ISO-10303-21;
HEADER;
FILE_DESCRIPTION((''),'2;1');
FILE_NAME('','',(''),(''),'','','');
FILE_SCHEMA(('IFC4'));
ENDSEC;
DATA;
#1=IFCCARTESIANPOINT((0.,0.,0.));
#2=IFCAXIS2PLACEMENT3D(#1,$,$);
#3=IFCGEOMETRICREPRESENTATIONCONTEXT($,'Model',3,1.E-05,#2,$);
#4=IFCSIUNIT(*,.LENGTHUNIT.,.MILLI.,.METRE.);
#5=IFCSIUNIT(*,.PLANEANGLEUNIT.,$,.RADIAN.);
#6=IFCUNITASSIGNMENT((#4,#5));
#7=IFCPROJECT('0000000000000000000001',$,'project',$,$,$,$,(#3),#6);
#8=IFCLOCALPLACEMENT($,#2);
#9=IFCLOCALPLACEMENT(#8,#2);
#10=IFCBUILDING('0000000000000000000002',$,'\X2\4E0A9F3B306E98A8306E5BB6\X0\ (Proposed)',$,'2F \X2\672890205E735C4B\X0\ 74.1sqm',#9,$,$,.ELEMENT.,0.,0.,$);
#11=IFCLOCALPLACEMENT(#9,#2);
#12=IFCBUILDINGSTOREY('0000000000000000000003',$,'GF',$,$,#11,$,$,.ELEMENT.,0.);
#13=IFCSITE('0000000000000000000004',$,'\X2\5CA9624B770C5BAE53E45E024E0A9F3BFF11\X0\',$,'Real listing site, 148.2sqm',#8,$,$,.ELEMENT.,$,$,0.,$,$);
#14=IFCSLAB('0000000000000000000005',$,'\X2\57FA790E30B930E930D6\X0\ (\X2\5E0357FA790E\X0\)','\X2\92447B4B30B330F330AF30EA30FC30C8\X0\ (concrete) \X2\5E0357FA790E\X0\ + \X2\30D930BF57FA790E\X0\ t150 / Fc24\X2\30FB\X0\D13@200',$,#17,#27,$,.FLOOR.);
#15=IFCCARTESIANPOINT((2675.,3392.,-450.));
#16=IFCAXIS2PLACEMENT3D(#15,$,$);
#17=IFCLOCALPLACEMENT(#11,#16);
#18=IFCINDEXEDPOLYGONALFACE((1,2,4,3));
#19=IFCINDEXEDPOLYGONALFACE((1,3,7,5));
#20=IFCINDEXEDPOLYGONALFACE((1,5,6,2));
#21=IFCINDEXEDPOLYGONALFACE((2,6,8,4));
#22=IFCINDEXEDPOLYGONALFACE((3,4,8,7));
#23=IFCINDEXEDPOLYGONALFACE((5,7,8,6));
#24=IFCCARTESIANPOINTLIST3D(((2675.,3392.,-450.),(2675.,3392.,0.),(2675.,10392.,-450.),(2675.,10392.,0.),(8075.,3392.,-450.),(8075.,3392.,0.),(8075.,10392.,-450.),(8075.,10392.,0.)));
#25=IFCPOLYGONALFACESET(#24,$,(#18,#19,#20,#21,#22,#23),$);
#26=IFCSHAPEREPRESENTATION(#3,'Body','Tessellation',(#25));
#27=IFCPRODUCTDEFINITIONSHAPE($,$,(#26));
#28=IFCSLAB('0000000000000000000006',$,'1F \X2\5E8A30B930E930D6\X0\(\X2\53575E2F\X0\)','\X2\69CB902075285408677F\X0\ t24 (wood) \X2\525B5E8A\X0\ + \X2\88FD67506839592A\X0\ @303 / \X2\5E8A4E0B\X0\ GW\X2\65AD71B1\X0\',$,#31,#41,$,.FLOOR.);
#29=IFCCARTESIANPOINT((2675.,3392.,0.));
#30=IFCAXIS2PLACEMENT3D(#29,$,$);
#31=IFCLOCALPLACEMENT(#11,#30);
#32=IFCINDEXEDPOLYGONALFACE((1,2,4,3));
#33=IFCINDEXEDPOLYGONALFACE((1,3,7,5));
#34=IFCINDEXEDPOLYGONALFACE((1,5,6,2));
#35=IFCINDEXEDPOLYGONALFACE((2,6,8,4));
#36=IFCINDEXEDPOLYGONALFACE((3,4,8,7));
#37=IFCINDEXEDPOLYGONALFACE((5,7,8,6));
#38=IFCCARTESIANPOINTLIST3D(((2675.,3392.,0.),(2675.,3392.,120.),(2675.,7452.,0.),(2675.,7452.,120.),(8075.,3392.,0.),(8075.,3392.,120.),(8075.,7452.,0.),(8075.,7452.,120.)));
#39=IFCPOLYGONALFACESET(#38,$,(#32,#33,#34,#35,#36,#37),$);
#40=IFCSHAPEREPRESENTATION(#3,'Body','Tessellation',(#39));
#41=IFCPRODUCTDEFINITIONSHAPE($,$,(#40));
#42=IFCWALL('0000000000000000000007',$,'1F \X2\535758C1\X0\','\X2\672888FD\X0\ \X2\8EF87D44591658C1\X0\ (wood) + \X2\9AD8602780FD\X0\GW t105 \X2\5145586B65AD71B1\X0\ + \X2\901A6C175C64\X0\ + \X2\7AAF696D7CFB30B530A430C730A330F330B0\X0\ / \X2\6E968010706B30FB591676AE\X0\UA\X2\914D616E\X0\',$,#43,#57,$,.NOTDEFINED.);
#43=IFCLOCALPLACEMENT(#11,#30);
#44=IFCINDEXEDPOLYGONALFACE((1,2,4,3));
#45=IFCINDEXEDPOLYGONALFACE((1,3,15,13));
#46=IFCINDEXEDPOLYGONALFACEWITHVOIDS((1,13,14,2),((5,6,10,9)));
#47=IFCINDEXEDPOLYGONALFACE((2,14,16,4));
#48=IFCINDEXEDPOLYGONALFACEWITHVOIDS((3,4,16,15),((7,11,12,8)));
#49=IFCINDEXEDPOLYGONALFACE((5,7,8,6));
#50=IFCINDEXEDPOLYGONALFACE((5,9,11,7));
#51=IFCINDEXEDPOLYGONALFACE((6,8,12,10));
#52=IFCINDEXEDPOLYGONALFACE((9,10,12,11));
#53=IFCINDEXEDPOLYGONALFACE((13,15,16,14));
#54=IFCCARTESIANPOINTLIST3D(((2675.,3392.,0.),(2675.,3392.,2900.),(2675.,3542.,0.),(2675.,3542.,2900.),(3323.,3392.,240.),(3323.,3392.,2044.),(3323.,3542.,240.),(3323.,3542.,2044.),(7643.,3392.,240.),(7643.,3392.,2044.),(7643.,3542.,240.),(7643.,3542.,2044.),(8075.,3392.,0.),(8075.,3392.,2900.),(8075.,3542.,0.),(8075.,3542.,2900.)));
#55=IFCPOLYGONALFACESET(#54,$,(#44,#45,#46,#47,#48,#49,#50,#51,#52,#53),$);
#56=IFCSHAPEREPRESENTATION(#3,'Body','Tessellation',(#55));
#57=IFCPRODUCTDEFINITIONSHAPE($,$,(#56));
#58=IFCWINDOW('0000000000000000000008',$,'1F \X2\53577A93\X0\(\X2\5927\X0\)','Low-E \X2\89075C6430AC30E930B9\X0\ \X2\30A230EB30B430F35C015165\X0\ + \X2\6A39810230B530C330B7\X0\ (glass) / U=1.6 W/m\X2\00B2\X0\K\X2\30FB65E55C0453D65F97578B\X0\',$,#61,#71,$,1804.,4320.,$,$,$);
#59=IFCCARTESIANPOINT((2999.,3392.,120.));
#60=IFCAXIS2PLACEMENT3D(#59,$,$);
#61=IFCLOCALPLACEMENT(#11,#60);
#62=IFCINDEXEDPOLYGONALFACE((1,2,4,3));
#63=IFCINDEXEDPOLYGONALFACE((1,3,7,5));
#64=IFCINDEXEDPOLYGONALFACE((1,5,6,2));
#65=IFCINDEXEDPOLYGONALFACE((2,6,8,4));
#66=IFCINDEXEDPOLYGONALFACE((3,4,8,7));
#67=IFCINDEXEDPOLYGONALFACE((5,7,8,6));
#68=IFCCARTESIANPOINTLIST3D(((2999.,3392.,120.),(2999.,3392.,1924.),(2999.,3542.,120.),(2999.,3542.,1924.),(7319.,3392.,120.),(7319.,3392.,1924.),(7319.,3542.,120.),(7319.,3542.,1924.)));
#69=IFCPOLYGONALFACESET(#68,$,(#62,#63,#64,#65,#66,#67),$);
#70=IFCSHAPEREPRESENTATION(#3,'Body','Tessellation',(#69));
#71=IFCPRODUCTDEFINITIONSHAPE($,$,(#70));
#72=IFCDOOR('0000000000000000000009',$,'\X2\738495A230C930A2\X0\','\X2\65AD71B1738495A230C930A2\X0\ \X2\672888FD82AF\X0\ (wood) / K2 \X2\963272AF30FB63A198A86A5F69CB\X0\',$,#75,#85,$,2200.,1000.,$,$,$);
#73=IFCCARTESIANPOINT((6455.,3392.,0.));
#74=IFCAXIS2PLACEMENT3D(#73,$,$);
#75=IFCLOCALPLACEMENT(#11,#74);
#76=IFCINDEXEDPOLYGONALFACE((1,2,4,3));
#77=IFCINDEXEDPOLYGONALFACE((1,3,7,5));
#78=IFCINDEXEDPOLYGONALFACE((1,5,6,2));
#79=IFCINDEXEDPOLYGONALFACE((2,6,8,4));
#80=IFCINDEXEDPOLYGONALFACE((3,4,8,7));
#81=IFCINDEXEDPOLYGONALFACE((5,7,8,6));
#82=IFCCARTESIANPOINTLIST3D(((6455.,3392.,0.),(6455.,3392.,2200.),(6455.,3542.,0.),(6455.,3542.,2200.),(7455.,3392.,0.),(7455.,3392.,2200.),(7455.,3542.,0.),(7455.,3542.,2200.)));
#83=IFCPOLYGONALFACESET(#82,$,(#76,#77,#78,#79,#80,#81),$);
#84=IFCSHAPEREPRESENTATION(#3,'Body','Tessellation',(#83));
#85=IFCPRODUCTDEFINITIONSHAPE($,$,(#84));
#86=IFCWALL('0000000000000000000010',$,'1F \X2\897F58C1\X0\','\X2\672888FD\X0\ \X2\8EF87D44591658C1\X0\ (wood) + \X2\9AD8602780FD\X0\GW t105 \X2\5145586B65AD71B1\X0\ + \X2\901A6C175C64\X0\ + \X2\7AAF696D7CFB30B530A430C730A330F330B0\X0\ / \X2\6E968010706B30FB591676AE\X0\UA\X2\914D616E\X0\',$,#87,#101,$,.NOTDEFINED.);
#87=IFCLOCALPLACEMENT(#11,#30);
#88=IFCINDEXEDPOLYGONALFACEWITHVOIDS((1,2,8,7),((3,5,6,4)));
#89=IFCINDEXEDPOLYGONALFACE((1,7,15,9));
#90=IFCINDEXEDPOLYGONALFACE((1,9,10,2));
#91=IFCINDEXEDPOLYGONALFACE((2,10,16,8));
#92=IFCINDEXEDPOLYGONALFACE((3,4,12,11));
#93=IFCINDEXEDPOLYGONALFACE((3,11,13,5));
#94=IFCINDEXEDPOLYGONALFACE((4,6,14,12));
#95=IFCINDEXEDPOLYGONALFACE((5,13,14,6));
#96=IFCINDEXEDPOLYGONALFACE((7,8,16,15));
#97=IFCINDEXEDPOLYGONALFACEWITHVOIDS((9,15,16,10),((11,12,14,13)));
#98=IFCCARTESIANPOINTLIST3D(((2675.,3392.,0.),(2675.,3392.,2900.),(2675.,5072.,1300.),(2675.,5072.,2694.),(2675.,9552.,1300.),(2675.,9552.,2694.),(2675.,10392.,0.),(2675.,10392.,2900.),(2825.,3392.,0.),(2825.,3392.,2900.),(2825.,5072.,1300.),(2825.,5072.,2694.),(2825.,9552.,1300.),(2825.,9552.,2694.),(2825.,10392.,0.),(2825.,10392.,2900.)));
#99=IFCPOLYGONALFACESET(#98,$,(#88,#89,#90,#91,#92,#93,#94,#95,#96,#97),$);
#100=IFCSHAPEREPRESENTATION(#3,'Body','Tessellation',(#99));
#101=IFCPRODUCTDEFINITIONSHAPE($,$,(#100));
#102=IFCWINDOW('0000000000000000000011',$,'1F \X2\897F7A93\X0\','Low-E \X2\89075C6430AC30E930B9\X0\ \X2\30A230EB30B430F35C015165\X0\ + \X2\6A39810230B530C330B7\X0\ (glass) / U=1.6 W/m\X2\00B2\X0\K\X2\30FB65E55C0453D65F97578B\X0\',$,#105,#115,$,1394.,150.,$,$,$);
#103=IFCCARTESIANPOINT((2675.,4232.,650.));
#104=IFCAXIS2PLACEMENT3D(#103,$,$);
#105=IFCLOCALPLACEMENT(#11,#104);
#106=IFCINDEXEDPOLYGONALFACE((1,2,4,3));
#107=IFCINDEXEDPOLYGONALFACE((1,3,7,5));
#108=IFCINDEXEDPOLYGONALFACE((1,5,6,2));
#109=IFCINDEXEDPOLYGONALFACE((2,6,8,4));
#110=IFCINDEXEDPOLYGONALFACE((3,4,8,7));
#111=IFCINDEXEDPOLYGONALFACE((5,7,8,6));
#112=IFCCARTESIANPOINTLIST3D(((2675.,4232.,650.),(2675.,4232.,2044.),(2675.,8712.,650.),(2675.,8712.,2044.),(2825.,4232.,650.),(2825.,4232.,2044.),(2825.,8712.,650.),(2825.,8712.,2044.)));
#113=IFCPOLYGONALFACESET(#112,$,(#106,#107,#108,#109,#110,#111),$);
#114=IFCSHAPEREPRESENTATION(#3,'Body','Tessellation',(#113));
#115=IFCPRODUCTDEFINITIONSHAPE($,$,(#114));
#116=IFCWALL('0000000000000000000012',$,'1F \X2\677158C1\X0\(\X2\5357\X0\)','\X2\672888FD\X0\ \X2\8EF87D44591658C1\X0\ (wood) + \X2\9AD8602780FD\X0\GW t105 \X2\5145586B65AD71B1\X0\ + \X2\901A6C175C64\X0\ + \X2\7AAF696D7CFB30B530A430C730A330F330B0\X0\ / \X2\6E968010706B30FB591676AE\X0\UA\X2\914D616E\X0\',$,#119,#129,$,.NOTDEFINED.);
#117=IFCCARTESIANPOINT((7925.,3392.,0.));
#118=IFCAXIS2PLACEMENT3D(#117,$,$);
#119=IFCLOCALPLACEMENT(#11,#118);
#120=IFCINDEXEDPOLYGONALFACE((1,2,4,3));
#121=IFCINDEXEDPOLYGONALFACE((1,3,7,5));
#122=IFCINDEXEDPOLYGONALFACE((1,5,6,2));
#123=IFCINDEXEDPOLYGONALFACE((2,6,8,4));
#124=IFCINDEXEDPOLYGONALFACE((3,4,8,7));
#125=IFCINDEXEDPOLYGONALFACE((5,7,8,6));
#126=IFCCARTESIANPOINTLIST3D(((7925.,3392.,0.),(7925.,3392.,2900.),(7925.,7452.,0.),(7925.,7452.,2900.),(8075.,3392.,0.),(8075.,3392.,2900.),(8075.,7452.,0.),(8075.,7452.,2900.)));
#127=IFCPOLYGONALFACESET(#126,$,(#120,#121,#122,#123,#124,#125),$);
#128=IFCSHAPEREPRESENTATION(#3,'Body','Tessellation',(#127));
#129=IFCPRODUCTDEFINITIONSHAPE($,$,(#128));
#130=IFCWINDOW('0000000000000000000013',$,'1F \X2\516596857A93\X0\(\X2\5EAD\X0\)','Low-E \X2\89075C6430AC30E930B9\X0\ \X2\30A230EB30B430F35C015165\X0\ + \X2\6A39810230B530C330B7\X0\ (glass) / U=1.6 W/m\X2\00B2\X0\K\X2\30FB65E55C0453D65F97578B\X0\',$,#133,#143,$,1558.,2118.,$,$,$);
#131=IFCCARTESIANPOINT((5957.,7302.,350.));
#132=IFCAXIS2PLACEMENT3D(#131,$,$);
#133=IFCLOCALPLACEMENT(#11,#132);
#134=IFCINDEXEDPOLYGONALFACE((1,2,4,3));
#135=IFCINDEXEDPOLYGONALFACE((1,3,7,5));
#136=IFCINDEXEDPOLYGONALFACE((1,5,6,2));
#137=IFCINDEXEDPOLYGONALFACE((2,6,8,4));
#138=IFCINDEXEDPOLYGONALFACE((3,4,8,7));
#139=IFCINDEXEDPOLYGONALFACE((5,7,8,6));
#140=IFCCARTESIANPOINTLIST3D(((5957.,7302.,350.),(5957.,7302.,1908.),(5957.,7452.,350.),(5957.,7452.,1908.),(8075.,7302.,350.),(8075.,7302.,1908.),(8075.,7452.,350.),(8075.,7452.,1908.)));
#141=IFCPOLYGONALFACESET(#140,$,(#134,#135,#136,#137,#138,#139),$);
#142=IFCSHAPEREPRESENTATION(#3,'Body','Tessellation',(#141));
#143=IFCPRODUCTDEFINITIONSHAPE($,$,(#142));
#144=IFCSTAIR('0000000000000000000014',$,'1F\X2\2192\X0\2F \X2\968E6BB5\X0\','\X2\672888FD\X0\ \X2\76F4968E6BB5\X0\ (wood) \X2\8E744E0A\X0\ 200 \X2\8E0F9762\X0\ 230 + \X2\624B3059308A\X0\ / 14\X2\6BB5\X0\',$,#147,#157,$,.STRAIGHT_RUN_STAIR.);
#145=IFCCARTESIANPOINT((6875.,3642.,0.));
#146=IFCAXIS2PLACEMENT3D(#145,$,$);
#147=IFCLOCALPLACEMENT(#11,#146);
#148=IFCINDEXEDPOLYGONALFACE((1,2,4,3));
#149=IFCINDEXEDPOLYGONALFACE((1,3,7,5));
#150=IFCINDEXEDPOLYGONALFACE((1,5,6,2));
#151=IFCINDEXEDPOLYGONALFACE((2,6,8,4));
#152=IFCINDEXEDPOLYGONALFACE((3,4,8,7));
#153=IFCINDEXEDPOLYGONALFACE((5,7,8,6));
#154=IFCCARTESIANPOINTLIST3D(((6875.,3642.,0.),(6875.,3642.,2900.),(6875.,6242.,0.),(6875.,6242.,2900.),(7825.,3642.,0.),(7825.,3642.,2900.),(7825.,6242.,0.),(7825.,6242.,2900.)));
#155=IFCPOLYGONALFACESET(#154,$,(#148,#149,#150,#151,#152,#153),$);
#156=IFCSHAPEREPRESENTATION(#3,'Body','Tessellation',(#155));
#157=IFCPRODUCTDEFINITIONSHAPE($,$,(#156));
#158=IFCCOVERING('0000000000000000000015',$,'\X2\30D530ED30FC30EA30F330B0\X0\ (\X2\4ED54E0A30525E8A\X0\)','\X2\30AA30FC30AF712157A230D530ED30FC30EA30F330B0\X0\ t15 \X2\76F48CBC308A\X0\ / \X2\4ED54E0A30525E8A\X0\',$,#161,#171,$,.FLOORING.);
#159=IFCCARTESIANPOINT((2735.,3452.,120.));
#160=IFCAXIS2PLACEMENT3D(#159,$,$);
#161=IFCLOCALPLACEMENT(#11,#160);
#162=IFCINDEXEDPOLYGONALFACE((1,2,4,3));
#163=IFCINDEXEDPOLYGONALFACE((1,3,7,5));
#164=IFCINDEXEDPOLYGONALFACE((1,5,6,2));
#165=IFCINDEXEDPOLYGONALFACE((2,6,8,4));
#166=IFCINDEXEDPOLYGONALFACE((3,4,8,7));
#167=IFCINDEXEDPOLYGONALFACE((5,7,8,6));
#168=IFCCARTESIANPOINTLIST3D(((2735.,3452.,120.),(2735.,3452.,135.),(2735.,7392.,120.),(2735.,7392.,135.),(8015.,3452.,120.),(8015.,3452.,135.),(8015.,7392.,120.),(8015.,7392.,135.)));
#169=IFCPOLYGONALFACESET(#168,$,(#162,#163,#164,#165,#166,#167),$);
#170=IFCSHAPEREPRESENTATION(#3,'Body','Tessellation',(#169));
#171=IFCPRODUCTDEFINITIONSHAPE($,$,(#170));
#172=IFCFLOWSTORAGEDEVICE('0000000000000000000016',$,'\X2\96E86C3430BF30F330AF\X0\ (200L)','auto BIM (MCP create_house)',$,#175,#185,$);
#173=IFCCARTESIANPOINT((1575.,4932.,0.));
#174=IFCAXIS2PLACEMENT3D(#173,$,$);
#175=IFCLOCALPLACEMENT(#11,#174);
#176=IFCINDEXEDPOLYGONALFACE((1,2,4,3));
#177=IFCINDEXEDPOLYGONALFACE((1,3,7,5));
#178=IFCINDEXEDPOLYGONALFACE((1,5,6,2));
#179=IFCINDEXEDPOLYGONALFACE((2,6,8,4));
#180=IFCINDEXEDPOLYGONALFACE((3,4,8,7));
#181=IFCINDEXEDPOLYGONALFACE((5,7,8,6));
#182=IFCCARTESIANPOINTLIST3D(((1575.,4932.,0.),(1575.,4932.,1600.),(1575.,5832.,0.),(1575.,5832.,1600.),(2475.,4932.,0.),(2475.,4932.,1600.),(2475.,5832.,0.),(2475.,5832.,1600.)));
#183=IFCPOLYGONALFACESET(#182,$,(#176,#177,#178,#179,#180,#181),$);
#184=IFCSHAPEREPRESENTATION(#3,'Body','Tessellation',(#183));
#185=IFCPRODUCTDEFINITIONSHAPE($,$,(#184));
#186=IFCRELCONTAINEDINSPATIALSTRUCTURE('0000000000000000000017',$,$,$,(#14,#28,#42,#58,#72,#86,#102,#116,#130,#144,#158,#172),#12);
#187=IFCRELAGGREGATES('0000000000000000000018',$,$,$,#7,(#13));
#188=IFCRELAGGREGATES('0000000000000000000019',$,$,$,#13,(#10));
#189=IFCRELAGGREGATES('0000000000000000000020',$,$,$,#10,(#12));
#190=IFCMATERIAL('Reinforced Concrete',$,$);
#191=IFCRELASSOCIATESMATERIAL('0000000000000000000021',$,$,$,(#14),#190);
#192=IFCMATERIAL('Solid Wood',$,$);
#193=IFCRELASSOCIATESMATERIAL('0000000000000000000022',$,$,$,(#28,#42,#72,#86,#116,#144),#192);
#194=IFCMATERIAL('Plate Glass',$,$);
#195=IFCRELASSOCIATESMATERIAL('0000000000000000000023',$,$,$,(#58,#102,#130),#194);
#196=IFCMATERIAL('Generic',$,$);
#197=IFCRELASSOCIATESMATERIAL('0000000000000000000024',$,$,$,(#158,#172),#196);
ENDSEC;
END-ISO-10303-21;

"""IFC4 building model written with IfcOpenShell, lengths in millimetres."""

from ifc_helpers import new_model, si_unit, frame, frame_2d, origin, place, context, project, spatial, rectangle, extrude, material, element, fill, save


model = new_model("IFC4")

# Units and contexts
model_context = context("Model", 3, precision=1e-05, world=origin())
ifc_project = project(units=[si_unit("LENGTHUNIT", "METRE", prefix="MILLI"), si_unit("PLANEANGLEUNIT", "RADIAN")], contexts=[model_context])

# Site, building, storey
site_placement = place(None, origin())
site = spatial("IfcSite", under=ifc_project, at=site_placement, Name="岩手県宮古市上鼻１", ObjectType="Real listing site, 148.2sqm", CompositionType="ELEMENT", RefElevation=0.0)
building_placement = place(site_placement, origin())
building = spatial("IfcBuilding", under=site, at=building_placement, Name="上鼻の風の家 (Proposed)", ObjectType="2F 木造平屋 74.1sqm", CompositionType="ELEMENT", ElevationOfRefHeight=0.0, ElevationOfTerrain=0.0)
storey_placement = place(building_placement, origin())
storey = spatial("IfcBuildingStorey", under=building, at=storey_placement, Name="GF", CompositionType="ELEMENT", Elevation=0.0)

# Slabs
ifc_material_1 = material(Name="Reinforced Concrete")
slab_1_placement = place(storey_placement, frame((2675.0, 3392.0, -450.0)))
element("IfcSlab", 1, at=slab_1_placement, inside=storey, material=ifc_material_1, Name="基礎スラブ (布基礎)", Description="鉄筋コンクリート (concrete) 布基礎 + ベタ基礎 t150 / Fc24・D13@200", PredefinedType="FLOOR", context=model_context, shape_type="SweptSolid", body=[
    extrude(rectangle(XDim=5400.0, YDim=7000.0, at=frame_2d((2700.0, 3500.0))), frame((2675.0, 3392.0, -450.0)), (0.0, 0.0, 1.0), 450.0),
])
ifc_material_2 = material(Name="Solid Wood")
slab_2_placement = place(storey_placement, frame((2675.0, 3392.0, 0.0)))
element("IfcSlab", 2, at=slab_2_placement, inside=storey, material=ifc_material_2, Name="1F 床スラブ(南帯)", Description="構造用合板 t24 (wood) 剛床 + 製材根太 @303 / 床下 GW断熱", PredefinedType="FLOOR", context=model_context, shape_type="SweptSolid", body=[
    extrude(rectangle(XDim=5400.0, YDim=4060.0, at=frame_2d((2700.0, 2030.0))), frame((2675.0, 3392.0, 0.0)), (0.0, 0.0, 1.0), 120.0),
])

# Wall, openings, window, door
wall_1_placement = place(storey_placement, frame((2675.0, 3392.0, 0.0)))
wall_1 = element("IfcWall", 3, at=wall_1_placement, inside=storey, material=ifc_material_2, Name="1F 南壁", Description="木製 軸組外壁 (wood) + 高性能GW t105 充填断熱 + 通気層 + 窯業系サイディング / 準耐火・外皮UA配慮", PredefinedType="NOTDEFINED", context=model_context, shape_type="SweptSolid", body=[
    extrude(rectangle(XDim=5400.0, YDim=150.0, at=frame_2d((2700.0, 75.0))), frame((2675.0, 3392.0, 0.0)), (0.0, 0.0, 1.0), 2900.0),
])
opening_1_placement = place(storey_placement, frame((2999.0, 3392.0, 120.0)))
opening_1 = element("IfcOpeningElement", 4, at=opening_1_placement, cuts=wall_1, PredefinedType="NOTDEFINED", context=model_context, shape_type="SweptSolid", body=[
    extrude(rectangle(XDim=4320.0, YDim=150.0, at=frame_2d((2160.0, 75.0))), frame((2999.0, 3392.0, 120.0)), (0.0, 0.0, 1.0), 1804.0),
])
opening_2_placement = place(storey_placement, frame((6455.0, 3392.0, 0.0)))
opening_2 = element("IfcOpeningElement", 5, at=opening_2_placement, cuts=wall_1, PredefinedType="NOTDEFINED", context=model_context, shape_type="SweptSolid", body=[
    extrude(rectangle(XDim=1000.0, YDim=150.0, at=frame_2d((500.0, 75.0))), frame((6455.0, 3392.0, 0.0)), (0.0, 0.0, 1.0), 2200.0),
])
ifc_material_3 = material(Name="Plate Glass")
window_1_placement = place(storey_placement, frame((2999.0, 3392.0, 120.0)))
window_1 = element("IfcWindow", 6, at=window_1_placement, inside=storey, material=ifc_material_3, Name="1F 南窓(大)", Description="Low-E 複層ガラス アルゴン封入 + 樹脂サッシ (glass) / U=1.6 W/m²K・日射取得型", OverallHeight=1804.0, OverallWidth=4320.0, context=model_context, shape_type="SweptSolid", body=[
    extrude(rectangle(XDim=4320.0, YDim=150.0, at=frame_2d((2160.0, 75.0))), frame((2999.0, 3392.0, 120.0)), (0.0, 0.0, 1.0), 1804.0),
])
fill(opening_1, window_1)
door_1_placement = place(storey_placement, frame((6455.0, 3392.0, 0.0)))
door_1 = element("IfcDoor", 7, at=door_1_placement, inside=storey, material=ifc_material_2, Name="玄関ドア", Description="断熱玄関ドア 木製芯 (wood) / K2 防犯・採風機構", OverallHeight=2200.0, OverallWidth=1000.0, context=model_context, shape_type="SweptSolid", body=[
    extrude(rectangle(XDim=1000.0, YDim=150.0, at=frame_2d((500.0, 75.0))), frame((6455.0, 3392.0, 0.0)), (0.0, 0.0, 1.0), 2200.0),
])
fill(opening_2, door_1)

# Walls, openings, windows
wall_2_placement = place(storey_placement, frame((2675.0, 3392.0, 0.0)))
wall_2 = element("IfcWall", 8, at=wall_2_placement, inside=storey, material=ifc_material_2, Name="1F 西壁", Description="木製 軸組外壁 (wood) + 高性能GW t105 充填断熱 + 通気層 + 窯業系サイディング / 準耐火・外皮UA配慮", PredefinedType="NOTDEFINED", context=model_context, shape_type="SweptSolid", body=[
    extrude(rectangle(XDim=150.0, YDim=7000.0, at=frame_2d((75.0, 3500.0))), frame((2675.0, 3392.0, 0.0)), (0.0, 0.0, 1.0), 2900.0),
])
opening_3_placement = place(storey_placement, frame((2675.0, 4232.0, 650.0)))
opening_3 = element("IfcOpeningElement", 9, at=opening_3_placement, cuts=wall_2, PredefinedType="NOTDEFINED", context=model_context, shape_type="SweptSolid", body=[
    extrude(rectangle(XDim=150.0, YDim=4480.0, at=frame_2d((75.0, 2240.0))), frame((2675.0, 4232.0, 650.0)), (0.0, 0.0, 1.0), 1394.0),
])
window_2_placement = place(storey_placement, frame((2675.0, 4232.0, 650.0)))
window_2 = element("IfcWindow", 10, at=window_2_placement, inside=storey, material=ifc_material_3, Name="1F 西窓", Description="Low-E 複層ガラス アルゴン封入 + 樹脂サッシ (glass) / U=1.6 W/m²K・日射取得型", OverallHeight=1394.0, OverallWidth=150.0, context=model_context, shape_type="SweptSolid", body=[
    extrude(rectangle(XDim=150.0, YDim=4480.0, at=frame_2d((75.0, 2240.0))), frame((2675.0, 4232.0, 650.0)), (0.0, 0.0, 1.0), 1394.0),
])
fill(opening_3, window_2)
wall_3_placement = place(storey_placement, frame((7925.0, 3392.0, 0.0)))
wall_3 = element("IfcWall", 11, at=wall_3_placement, inside=storey, material=ifc_material_2, Name="1F 東壁(南)", Description="木製 軸組外壁 (wood) + 高性能GW t105 充填断熱 + 通気層 + 窯業系サイディング / 準耐火・外皮UA配慮", PredefinedType="NOTDEFINED", context=model_context, shape_type="SweptSolid", body=[
    extrude(rectangle(XDim=150.0, YDim=4060.0, at=frame_2d((75.0, 2030.0))), frame((7925.0, 3392.0, 0.0)), (0.0, 0.0, 1.0), 2900.0),
])
opening_4_placement = place(storey_placement, frame((5957.0, 7302.0, 350.0)))
opening_4 = element("IfcOpeningElement", 12, at=opening_4_placement, cuts=wall_3, PredefinedType="NOTDEFINED", context=model_context, shape_type="SweptSolid", body=[
    extrude(rectangle(XDim=2118.0, YDim=150.0, at=frame_2d((1059.0, 75.0))), frame((5957.0, 7302.0, 350.0)), (0.0, 0.0, 1.0), 1558.0),
])
window_3_placement = place(storey_placement, frame((5957.0, 7302.0, 350.0)))
window_3 = element("IfcWindow", 13, at=window_3_placement, inside=storey, material=ifc_material_3, Name="1F 入隅窓(庭)", Description="Low-E 複層ガラス アルゴン封入 + 樹脂サッシ (glass) / U=1.6 W/m²K・日射取得型", OverallHeight=1558.0, OverallWidth=2118.0, context=model_context, shape_type="SweptSolid", body=[
    extrude(rectangle(XDim=2118.0, YDim=150.0, at=frame_2d((1059.0, 75.0))), frame((5957.0, 7302.0, 350.0)), (0.0, 0.0, 1.0), 1558.0),
])
fill(opening_4, window_3)

# Stair
stair_placement = place(storey_placement, frame((6875.0, 3642.0, 0.0)))
element("IfcStair", 14, at=stair_placement, inside=storey, material=ifc_material_2, Name="1F→2F 階段", Description="木製 直階段 (wood) 蹴上 200 踏面 230 + 手すり / 14段", PredefinedType="STRAIGHT_RUN_STAIR", context=model_context, shape_type="SweptSolid", body=[
    extrude(rectangle(XDim=950.0, YDim=2600.0, at=frame_2d((475.0, 1300.0))), frame((6875.0, 3642.0, 0.0)), (0.0, 0.0, 1.0), 2900.0),
])

# Covering
ifc_material_4 = material(Name="Generic")
covering_placement = place(storey_placement, frame((2735.0, 3452.0, 120.0)))
element("IfcCovering", 15, at=covering_placement, inside=storey, material=ifc_material_4, Name="フローリング (仕上げ床)", Description="オーク無垢フローリング t15 直貼り / 仕上げ床", PredefinedType="FLOORING", context=model_context, shape_type="SweptSolid", body=[
    extrude(rectangle(XDim=5280.0, YDim=3940.0, at=frame_2d((2640.0, 1970.0))), frame((2735.0, 3452.0, 120.0)), (0.0, 0.0, 1.0), 15.0),
])

# Flow storage device
flow_storage_device_placement = place(storey_placement, frame((1575.0, 4932.0, 0.0)))
element("IfcFlowStorageDevice", 16, at=flow_storage_device_placement, inside=storey, material=ifc_material_4, Name="雨水タンク (200L)", Description="auto BIM (MCP create_house)", context=model_context, shape_type="SweptSolid", body=[
    extrude(rectangle(XDim=900.0, YDim=900.0, at=frame_2d((450.0, 450.0))), frame((1575.0, 4932.0, 0.0)), (0.0, 0.0, 1.0), 1600.0),
])

save(model, "model.ifc")
